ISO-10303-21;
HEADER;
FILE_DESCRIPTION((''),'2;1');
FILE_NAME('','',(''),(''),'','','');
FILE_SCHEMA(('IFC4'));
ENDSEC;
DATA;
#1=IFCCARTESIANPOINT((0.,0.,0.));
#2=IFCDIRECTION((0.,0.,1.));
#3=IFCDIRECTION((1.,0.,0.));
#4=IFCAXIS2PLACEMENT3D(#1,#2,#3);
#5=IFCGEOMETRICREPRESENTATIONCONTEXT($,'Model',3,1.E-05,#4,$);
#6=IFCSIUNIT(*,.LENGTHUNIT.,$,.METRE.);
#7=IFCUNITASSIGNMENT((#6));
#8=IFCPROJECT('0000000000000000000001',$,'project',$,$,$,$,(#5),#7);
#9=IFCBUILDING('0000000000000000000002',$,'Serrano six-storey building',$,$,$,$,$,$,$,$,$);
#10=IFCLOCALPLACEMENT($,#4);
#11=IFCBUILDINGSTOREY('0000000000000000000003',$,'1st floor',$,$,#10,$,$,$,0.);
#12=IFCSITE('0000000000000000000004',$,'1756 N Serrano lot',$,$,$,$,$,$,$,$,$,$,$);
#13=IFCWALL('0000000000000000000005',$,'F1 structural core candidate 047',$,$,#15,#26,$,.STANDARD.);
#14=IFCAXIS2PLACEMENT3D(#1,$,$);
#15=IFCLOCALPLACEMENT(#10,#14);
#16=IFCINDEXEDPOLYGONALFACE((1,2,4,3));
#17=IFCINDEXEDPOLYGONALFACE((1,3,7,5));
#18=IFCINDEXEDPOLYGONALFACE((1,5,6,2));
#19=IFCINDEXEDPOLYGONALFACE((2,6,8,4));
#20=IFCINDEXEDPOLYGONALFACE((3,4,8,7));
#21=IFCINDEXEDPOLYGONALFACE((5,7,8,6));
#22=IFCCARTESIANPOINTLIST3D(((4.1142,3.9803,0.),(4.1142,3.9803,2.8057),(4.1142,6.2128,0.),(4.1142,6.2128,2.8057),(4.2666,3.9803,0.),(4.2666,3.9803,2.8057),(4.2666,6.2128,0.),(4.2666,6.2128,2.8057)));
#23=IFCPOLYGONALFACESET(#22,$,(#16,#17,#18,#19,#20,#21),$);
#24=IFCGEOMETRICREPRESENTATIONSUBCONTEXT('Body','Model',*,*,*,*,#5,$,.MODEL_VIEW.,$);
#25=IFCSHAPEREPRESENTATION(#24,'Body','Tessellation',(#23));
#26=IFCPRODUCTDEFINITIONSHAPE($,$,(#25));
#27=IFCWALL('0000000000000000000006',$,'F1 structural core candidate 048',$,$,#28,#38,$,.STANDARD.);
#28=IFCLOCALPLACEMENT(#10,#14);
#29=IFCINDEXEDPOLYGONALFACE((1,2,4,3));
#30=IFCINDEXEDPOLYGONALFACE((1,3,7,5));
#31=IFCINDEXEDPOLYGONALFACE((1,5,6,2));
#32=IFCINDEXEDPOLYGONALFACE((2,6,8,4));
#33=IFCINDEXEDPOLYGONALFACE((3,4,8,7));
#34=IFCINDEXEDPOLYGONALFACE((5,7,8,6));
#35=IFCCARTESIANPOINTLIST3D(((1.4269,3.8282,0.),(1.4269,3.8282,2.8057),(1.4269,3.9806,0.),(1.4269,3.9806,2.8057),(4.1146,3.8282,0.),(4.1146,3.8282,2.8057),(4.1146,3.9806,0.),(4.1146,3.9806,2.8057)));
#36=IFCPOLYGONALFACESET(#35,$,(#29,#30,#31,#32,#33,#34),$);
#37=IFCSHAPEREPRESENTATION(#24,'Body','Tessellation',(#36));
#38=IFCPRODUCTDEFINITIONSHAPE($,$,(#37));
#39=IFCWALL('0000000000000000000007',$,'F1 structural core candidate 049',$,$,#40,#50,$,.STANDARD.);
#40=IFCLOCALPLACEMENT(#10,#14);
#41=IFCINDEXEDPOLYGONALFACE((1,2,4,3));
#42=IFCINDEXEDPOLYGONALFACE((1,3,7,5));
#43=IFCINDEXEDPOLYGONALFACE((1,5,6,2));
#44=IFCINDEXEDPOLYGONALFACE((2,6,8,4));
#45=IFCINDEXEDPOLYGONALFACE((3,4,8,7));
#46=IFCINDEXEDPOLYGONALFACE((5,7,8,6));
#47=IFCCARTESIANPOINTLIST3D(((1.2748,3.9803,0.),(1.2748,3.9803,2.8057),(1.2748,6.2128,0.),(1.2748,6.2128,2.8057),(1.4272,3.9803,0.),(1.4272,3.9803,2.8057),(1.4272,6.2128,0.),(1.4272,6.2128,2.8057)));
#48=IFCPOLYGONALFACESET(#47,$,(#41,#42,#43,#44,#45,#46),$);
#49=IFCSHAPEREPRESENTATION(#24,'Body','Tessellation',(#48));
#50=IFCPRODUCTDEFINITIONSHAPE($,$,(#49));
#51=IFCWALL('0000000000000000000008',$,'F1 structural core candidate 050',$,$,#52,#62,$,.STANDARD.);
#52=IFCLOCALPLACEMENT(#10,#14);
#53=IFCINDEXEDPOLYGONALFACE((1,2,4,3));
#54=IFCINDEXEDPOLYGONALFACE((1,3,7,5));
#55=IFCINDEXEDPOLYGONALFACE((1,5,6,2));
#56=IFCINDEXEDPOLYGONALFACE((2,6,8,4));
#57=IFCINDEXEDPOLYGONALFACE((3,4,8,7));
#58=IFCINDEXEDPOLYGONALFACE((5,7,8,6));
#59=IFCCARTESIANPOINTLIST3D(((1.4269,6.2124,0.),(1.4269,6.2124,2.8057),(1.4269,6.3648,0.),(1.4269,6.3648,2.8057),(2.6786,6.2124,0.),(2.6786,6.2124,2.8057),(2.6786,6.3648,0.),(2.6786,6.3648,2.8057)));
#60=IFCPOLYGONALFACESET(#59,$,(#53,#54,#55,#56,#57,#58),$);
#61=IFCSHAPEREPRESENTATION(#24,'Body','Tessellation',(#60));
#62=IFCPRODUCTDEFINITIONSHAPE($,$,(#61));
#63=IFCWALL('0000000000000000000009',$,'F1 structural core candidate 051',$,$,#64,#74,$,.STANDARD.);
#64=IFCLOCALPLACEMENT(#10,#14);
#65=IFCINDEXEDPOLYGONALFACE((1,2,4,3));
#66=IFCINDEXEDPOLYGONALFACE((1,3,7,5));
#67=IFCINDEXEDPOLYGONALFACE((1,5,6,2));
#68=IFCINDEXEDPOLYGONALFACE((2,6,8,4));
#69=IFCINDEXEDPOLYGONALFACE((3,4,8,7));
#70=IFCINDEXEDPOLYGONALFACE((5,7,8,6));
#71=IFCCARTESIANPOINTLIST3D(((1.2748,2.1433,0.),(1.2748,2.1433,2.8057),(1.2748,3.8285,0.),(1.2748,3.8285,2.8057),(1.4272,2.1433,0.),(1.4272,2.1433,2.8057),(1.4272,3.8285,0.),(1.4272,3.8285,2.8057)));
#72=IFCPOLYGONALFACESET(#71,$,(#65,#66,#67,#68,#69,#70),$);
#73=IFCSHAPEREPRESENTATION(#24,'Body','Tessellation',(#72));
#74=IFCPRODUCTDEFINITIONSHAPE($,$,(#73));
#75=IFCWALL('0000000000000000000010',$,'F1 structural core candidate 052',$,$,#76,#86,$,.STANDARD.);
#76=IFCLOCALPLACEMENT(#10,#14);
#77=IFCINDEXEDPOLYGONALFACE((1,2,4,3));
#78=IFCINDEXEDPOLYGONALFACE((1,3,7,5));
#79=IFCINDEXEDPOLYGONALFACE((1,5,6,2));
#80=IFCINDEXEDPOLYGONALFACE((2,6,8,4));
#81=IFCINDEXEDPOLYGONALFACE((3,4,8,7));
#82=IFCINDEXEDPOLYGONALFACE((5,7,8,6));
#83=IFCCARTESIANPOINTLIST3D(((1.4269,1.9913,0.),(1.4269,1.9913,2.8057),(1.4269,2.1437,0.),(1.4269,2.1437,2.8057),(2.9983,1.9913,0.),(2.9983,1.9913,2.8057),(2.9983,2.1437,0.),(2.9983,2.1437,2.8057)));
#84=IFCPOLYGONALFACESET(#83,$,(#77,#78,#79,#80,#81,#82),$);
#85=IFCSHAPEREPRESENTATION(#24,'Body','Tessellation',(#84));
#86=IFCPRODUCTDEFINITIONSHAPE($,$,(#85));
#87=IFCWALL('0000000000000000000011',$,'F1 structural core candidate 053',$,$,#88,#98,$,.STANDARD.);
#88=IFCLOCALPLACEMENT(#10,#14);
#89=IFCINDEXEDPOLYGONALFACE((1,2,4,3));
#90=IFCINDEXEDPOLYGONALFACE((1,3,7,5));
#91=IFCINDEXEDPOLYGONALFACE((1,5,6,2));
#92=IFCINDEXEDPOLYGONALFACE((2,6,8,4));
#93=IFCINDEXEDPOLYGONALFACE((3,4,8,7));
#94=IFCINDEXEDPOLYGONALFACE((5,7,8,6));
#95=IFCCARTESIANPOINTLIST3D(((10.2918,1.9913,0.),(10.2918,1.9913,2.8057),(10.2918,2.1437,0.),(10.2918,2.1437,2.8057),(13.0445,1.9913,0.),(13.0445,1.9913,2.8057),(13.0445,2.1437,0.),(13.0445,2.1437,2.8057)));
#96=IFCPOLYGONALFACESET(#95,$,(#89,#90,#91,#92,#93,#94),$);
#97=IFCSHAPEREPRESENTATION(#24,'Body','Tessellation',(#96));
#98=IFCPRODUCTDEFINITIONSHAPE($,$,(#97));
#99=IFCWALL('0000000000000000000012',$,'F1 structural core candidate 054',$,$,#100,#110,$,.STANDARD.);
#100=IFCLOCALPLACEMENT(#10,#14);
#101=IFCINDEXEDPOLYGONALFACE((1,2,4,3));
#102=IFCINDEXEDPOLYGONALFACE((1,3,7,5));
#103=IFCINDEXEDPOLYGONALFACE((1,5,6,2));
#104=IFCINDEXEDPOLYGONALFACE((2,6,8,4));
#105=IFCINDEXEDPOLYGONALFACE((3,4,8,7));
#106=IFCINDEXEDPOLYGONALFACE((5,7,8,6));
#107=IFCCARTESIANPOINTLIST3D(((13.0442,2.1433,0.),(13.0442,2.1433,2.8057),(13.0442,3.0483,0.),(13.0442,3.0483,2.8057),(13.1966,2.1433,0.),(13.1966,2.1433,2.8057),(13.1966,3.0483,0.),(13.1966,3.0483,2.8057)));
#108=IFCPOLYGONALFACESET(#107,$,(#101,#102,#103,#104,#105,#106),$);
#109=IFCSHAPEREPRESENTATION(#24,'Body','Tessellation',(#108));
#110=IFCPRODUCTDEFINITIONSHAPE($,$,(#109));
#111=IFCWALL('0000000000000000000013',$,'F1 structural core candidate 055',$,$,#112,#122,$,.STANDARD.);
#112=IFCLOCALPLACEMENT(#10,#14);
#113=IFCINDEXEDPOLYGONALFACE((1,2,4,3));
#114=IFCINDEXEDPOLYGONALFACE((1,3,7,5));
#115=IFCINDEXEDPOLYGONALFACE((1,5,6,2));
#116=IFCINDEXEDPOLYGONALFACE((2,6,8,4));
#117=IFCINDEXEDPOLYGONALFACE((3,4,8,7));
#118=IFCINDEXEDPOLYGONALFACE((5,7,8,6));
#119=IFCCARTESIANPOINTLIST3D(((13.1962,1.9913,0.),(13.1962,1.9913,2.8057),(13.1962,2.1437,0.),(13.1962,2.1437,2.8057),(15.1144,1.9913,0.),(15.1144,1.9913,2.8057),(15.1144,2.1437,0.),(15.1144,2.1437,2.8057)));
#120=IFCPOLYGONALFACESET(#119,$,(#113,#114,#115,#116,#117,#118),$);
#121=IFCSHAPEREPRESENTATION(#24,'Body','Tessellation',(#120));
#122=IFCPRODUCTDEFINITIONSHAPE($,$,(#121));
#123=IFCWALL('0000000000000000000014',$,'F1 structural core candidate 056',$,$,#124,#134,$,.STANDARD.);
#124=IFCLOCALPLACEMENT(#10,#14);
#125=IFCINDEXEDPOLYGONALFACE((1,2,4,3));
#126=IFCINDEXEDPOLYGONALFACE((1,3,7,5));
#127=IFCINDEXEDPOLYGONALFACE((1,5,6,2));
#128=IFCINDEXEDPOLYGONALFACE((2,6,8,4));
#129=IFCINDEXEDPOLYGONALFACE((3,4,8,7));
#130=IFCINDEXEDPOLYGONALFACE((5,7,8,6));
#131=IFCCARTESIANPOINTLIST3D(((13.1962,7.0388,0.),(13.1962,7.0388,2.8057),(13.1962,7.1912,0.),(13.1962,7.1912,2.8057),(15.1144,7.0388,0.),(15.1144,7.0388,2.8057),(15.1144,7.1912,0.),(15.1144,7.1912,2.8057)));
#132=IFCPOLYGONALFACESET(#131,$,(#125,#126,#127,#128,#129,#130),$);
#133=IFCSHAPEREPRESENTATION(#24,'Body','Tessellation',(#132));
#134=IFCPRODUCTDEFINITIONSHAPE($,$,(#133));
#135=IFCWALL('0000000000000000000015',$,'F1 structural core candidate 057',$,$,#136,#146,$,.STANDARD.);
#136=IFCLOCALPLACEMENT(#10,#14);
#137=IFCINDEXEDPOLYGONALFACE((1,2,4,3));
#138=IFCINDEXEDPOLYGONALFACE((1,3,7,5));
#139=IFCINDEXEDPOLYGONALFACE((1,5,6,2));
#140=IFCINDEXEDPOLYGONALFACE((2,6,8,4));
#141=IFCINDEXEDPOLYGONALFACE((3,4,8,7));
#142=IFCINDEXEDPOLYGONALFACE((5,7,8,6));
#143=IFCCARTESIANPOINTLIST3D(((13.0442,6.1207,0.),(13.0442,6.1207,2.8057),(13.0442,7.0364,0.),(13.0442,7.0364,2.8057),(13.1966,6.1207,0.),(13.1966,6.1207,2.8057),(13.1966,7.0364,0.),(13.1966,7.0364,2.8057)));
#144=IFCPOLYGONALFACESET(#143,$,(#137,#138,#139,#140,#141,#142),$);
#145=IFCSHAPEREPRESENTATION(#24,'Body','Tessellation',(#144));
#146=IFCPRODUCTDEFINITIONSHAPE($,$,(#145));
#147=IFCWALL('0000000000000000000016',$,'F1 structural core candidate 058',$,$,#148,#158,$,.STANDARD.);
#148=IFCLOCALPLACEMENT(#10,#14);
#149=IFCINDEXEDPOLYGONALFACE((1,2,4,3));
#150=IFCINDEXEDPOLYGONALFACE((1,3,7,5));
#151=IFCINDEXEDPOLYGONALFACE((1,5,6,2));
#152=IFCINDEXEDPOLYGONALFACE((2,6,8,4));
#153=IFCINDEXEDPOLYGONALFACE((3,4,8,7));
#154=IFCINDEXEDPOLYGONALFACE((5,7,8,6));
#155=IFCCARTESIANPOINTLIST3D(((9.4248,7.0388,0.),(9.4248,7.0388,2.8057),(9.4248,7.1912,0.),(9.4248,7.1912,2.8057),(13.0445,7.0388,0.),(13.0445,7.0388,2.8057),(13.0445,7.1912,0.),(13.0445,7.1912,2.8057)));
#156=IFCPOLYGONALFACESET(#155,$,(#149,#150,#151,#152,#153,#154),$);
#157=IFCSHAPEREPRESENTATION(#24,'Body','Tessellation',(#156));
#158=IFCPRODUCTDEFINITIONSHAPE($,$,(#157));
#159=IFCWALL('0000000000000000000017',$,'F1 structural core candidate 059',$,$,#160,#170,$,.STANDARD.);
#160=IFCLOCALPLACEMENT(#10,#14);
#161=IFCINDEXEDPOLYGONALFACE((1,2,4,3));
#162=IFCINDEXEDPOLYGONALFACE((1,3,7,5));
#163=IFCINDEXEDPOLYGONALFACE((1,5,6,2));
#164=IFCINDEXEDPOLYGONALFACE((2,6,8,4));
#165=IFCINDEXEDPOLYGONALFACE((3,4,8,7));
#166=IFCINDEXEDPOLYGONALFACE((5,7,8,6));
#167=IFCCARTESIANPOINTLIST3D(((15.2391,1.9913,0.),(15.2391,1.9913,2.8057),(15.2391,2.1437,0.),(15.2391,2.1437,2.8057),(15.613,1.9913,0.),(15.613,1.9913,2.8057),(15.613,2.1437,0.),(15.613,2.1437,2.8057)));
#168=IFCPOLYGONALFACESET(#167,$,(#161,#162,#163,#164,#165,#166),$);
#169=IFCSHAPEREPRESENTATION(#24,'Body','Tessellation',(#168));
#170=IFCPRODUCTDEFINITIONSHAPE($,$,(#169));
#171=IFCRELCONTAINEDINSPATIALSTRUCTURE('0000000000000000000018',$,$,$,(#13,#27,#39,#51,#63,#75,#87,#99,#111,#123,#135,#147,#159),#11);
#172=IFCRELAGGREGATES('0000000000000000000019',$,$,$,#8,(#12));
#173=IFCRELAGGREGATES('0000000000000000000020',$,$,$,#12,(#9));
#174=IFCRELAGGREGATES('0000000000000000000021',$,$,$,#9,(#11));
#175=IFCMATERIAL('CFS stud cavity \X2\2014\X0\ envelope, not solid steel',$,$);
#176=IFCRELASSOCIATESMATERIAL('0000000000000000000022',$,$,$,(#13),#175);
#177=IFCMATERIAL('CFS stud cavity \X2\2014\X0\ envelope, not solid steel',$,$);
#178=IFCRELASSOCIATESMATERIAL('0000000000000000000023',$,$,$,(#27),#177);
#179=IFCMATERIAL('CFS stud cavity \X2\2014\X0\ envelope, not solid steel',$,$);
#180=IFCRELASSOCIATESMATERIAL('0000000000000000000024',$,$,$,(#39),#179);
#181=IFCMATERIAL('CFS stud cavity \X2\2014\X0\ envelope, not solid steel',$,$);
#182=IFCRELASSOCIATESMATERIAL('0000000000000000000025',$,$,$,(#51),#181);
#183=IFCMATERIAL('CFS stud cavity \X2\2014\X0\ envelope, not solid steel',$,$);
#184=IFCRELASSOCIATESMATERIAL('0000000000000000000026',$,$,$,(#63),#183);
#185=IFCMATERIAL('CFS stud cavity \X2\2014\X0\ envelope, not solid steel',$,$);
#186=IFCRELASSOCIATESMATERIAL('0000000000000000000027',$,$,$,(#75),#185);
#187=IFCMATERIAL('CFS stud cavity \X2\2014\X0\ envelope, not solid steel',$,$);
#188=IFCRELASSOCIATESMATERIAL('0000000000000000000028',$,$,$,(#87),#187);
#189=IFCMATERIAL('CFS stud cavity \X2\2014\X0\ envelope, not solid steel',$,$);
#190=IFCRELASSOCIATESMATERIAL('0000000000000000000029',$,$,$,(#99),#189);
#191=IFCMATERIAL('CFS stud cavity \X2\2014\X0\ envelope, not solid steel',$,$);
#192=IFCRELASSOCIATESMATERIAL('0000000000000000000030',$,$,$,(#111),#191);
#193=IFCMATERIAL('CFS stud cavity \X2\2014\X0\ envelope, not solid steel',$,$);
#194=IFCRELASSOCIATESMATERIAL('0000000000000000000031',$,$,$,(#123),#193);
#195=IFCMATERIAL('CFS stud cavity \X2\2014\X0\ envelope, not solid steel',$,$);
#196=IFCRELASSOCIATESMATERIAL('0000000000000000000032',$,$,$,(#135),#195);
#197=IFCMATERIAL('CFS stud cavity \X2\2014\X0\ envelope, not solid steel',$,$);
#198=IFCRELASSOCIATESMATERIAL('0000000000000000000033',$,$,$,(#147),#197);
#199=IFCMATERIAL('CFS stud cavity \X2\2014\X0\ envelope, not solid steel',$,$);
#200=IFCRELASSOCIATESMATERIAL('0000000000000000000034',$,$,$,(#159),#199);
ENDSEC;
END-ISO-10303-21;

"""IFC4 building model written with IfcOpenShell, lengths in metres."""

from ifc_helpers import new_model, si_unit, origin, origin_with_axes, place, context, subcontext, project, spatial, polyline, outline, extrude, material, element, save


model = new_model("IFC4")

# Units and contexts
model_context = context("Model", 3, precision=1e-05, world=origin_with_axes())
body_context = subcontext(model_context, "Body", "Model", "MODEL_VIEW")
ifc_project = project(units=[si_unit("LENGTHUNIT", "METRE")], contexts=[model_context])

# Site, building, storey
site = spatial("IfcSite", under=ifc_project, Name="1756 N Serrano lot")
building = spatial("IfcBuilding", under=site, Name="Serrano six-storey building")
storey_placement = place(None, origin_with_axes())
storey = spatial("IfcBuildingStorey", under=building, at=storey_placement, Name="1st floor", Elevation=0.0)

# Walls
ifc_material_1 = material(Name="CFS stud cavity — envelope, not solid steel")
wall_1_placement = place(storey_placement, origin_with_axes())
element("IfcWall", 1, at=wall_1_placement, inside=storey, material=ifc_material_1, Name="F1 structural core candidate 047", PredefinedType="STANDARD", context=body_context, shape_type="SweptSolid", body=[
    extrude(outline(polyline([(4.2666, 3.9803), (4.1142, 3.9803), (4.1142, 6.2128), (4.2666, 6.2128), (4.2666, 3.9803)])), origin(), (0.0, 0.0, 1.0), 2.8057),
])
ifc_material_2 = material(Name="CFS stud cavity — envelope, not solid steel")
wall_2_placement = place(storey_placement, origin_with_axes())
element("IfcWall", 2, at=wall_2_placement, inside=storey, material=ifc_material_2, Name="F1 structural core candidate 048", PredefinedType="STANDARD", context=body_context, shape_type="SweptSolid", body=[
    extrude(outline(polyline([(4.1146, 3.9806), (4.1146, 3.8282), (1.4269, 3.8282), (1.4269, 3.9806), (4.1146, 3.9806)])), origin(), (0.0, 0.0, 1.0), 2.8057),
])
ifc_material_3 = material(Name="CFS stud cavity — envelope, not solid steel")
wall_3_placement = place(storey_placement, origin_with_axes())
element("IfcWall", 3, at=wall_3_placement, inside=storey, material=ifc_material_3, Name="F1 structural core candidate 049", PredefinedType="STANDARD", context=body_context, shape_type="SweptSolid", body=[
    extrude(outline(polyline([(1.4272, 3.9803), (1.2748, 3.9803), (1.2748, 6.2128), (1.4272, 6.2128), (1.4272, 3.9803)])), origin(), (0.0, 0.0, 1.0), 2.8057),
])
ifc_material_4 = material(Name="CFS stud cavity — envelope, not solid steel")
wall_4_placement = place(storey_placement, origin_with_axes())
element("IfcWall", 4, at=wall_4_placement, inside=storey, material=ifc_material_4, Name="F1 structural core candidate 050", PredefinedType="STANDARD", context=body_context, shape_type="SweptSolid", body=[
    extrude(outline(polyline([(2.6786, 6.3648), (2.6786, 6.2124), (1.4269, 6.2124), (1.4269, 6.3648), (2.6786, 6.3648)])), origin(), (0.0, 0.0, 1.0), 2.8057),
])
ifc_material_5 = material(Name="CFS stud cavity — envelope, not solid steel")
wall_5_placement = place(storey_placement, origin_with_axes())
element("IfcWall", 5, at=wall_5_placement, inside=storey, material=ifc_material_5, Name="F1 structural core candidate 051", PredefinedType="STANDARD", context=body_context, shape_type="SweptSolid", body=[
    extrude(outline(polyline([(1.4272, 2.1433), (1.2748, 2.1433), (1.2748, 3.8285), (1.4272, 3.8285), (1.4272, 2.1433)])), origin(), (0.0, 0.0, 1.0), 2.8057),
])
ifc_material_6 = material(Name="CFS stud cavity — envelope, not solid steel")
wall_6_placement = place(storey_placement, origin_with_axes())
element("IfcWall", 6, at=wall_6_placement, inside=storey, material=ifc_material_6, Name="F1 structural core candidate 052", PredefinedType="STANDARD", context=body_context, shape_type="SweptSolid", body=[
    extrude(outline(polyline([(2.9983, 2.1437), (2.9983, 1.9913), (1.4269, 1.9913), (1.4269, 2.1437), (2.9983, 2.1437)])), origin(), (0.0, 0.0, 1.0), 2.8057),
])
ifc_material_7 = material(Name="CFS stud cavity — envelope, not solid steel")
wall_7_placement = place(storey_placement, origin_with_axes())
element("IfcWall", 7, at=wall_7_placement, inside=storey, material=ifc_material_7, Name="F1 structural core candidate 053", PredefinedType="STANDARD", context=body_context, shape_type="SweptSolid", body=[
    extrude(outline(polyline([(13.0445, 2.1437), (13.0445, 1.9913), (10.2918, 1.9913), (10.2918, 2.1437), (13.0445, 2.1437)])), origin(), (0.0, 0.0, 1.0), 2.8057),
])
ifc_material_8 = material(Name="CFS stud cavity — envelope, not solid steel")
wall_8_placement = place(storey_placement, origin_with_axes())
element("IfcWall", 8, at=wall_8_placement, inside=storey, material=ifc_material_8, Name="F1 structural core candidate 054", PredefinedType="STANDARD", context=body_context, shape_type="SweptSolid", body=[
    extrude(outline(polyline([(13.1966, 2.1433), (13.0442, 2.1433), (13.0442, 3.0483), (13.1966, 3.0483), (13.1966, 2.1433)])), origin(), (0.0, 0.0, 1.0), 2.8057),
])
ifc_material_9 = material(Name="CFS stud cavity — envelope, not solid steel")
wall_9_placement = place(storey_placement, origin_with_axes())
element("IfcWall", 9, at=wall_9_placement, inside=storey, material=ifc_material_9, Name="F1 structural core candidate 055", PredefinedType="STANDARD", context=body_context, shape_type="SweptSolid", body=[
    extrude(outline(polyline([(15.1144, 2.1437), (15.1144, 1.9913), (13.1962, 1.9913), (13.1962, 2.1437), (15.1144, 2.1437)])), origin(), (0.0, 0.0, 1.0), 2.8057),
])
ifc_material_10 = material(Name="CFS stud cavity — envelope, not solid steel")
wall_10_placement = place(storey_placement, origin_with_axes())
element("IfcWall", 10, at=wall_10_placement, inside=storey, material=ifc_material_10, Name="F1 structural core candidate 056", PredefinedType="STANDARD", context=body_context, shape_type="SweptSolid", body=[
    extrude(outline(polyline([(15.1144, 7.1912), (15.1144, 7.0388), (13.1962, 7.0388), (13.1962, 7.1912), (15.1144, 7.1912)])), origin(), (0.0, 0.0, 1.0), 2.8057),
])
ifc_material_11 = material(Name="CFS stud cavity — envelope, not solid steel")
wall_11_placement = place(storey_placement, origin_with_axes())
element("IfcWall", 11, at=wall_11_placement, inside=storey, material=ifc_material_11, Name="F1 structural core candidate 057", PredefinedType="STANDARD", context=body_context, shape_type="SweptSolid", body=[
    extrude(outline(polyline([(13.1966, 6.1207), (13.0442, 6.1207), (13.0442, 7.0364), (13.1966, 7.0364), (13.1966, 6.1207)])), origin(), (0.0, 0.0, 1.0), 2.8057),
])
ifc_material_12 = material(Name="CFS stud cavity — envelope, not solid steel")
wall_12_placement = place(storey_placement, origin_with_axes())
element("IfcWall", 12, at=wall_12_placement, inside=storey, material=ifc_material_12, Name="F1 structural core candidate 058", PredefinedType="STANDARD", context=body_context, shape_type="SweptSolid", body=[
    extrude(outline(polyline([(13.0445, 7.1912), (13.0445, 7.0388), (9.4248, 7.0388), (9.4248, 7.1912), (13.0445, 7.1912)])), origin(), (0.0, 0.0, 1.0), 2.8057),
])
ifc_material_13 = material(Name="CFS stud cavity — envelope, not solid steel")
wall_13_placement = place(storey_placement, origin_with_axes())
element("IfcWall", 13, at=wall_13_placement, inside=storey, material=ifc_material_13, Name="F1 structural core candidate 059", PredefinedType="STANDARD", context=body_context, shape_type="SweptSolid", body=[
    extrude(outline(polyline([(15.613, 2.1437), (15.613, 1.9913), (15.2391, 1.9913), (15.2391, 2.1437), (15.613, 2.1437)])), origin(), (0.0, 0.0, 1.0), 2.8057),
])

save(model, "model.ifc")
